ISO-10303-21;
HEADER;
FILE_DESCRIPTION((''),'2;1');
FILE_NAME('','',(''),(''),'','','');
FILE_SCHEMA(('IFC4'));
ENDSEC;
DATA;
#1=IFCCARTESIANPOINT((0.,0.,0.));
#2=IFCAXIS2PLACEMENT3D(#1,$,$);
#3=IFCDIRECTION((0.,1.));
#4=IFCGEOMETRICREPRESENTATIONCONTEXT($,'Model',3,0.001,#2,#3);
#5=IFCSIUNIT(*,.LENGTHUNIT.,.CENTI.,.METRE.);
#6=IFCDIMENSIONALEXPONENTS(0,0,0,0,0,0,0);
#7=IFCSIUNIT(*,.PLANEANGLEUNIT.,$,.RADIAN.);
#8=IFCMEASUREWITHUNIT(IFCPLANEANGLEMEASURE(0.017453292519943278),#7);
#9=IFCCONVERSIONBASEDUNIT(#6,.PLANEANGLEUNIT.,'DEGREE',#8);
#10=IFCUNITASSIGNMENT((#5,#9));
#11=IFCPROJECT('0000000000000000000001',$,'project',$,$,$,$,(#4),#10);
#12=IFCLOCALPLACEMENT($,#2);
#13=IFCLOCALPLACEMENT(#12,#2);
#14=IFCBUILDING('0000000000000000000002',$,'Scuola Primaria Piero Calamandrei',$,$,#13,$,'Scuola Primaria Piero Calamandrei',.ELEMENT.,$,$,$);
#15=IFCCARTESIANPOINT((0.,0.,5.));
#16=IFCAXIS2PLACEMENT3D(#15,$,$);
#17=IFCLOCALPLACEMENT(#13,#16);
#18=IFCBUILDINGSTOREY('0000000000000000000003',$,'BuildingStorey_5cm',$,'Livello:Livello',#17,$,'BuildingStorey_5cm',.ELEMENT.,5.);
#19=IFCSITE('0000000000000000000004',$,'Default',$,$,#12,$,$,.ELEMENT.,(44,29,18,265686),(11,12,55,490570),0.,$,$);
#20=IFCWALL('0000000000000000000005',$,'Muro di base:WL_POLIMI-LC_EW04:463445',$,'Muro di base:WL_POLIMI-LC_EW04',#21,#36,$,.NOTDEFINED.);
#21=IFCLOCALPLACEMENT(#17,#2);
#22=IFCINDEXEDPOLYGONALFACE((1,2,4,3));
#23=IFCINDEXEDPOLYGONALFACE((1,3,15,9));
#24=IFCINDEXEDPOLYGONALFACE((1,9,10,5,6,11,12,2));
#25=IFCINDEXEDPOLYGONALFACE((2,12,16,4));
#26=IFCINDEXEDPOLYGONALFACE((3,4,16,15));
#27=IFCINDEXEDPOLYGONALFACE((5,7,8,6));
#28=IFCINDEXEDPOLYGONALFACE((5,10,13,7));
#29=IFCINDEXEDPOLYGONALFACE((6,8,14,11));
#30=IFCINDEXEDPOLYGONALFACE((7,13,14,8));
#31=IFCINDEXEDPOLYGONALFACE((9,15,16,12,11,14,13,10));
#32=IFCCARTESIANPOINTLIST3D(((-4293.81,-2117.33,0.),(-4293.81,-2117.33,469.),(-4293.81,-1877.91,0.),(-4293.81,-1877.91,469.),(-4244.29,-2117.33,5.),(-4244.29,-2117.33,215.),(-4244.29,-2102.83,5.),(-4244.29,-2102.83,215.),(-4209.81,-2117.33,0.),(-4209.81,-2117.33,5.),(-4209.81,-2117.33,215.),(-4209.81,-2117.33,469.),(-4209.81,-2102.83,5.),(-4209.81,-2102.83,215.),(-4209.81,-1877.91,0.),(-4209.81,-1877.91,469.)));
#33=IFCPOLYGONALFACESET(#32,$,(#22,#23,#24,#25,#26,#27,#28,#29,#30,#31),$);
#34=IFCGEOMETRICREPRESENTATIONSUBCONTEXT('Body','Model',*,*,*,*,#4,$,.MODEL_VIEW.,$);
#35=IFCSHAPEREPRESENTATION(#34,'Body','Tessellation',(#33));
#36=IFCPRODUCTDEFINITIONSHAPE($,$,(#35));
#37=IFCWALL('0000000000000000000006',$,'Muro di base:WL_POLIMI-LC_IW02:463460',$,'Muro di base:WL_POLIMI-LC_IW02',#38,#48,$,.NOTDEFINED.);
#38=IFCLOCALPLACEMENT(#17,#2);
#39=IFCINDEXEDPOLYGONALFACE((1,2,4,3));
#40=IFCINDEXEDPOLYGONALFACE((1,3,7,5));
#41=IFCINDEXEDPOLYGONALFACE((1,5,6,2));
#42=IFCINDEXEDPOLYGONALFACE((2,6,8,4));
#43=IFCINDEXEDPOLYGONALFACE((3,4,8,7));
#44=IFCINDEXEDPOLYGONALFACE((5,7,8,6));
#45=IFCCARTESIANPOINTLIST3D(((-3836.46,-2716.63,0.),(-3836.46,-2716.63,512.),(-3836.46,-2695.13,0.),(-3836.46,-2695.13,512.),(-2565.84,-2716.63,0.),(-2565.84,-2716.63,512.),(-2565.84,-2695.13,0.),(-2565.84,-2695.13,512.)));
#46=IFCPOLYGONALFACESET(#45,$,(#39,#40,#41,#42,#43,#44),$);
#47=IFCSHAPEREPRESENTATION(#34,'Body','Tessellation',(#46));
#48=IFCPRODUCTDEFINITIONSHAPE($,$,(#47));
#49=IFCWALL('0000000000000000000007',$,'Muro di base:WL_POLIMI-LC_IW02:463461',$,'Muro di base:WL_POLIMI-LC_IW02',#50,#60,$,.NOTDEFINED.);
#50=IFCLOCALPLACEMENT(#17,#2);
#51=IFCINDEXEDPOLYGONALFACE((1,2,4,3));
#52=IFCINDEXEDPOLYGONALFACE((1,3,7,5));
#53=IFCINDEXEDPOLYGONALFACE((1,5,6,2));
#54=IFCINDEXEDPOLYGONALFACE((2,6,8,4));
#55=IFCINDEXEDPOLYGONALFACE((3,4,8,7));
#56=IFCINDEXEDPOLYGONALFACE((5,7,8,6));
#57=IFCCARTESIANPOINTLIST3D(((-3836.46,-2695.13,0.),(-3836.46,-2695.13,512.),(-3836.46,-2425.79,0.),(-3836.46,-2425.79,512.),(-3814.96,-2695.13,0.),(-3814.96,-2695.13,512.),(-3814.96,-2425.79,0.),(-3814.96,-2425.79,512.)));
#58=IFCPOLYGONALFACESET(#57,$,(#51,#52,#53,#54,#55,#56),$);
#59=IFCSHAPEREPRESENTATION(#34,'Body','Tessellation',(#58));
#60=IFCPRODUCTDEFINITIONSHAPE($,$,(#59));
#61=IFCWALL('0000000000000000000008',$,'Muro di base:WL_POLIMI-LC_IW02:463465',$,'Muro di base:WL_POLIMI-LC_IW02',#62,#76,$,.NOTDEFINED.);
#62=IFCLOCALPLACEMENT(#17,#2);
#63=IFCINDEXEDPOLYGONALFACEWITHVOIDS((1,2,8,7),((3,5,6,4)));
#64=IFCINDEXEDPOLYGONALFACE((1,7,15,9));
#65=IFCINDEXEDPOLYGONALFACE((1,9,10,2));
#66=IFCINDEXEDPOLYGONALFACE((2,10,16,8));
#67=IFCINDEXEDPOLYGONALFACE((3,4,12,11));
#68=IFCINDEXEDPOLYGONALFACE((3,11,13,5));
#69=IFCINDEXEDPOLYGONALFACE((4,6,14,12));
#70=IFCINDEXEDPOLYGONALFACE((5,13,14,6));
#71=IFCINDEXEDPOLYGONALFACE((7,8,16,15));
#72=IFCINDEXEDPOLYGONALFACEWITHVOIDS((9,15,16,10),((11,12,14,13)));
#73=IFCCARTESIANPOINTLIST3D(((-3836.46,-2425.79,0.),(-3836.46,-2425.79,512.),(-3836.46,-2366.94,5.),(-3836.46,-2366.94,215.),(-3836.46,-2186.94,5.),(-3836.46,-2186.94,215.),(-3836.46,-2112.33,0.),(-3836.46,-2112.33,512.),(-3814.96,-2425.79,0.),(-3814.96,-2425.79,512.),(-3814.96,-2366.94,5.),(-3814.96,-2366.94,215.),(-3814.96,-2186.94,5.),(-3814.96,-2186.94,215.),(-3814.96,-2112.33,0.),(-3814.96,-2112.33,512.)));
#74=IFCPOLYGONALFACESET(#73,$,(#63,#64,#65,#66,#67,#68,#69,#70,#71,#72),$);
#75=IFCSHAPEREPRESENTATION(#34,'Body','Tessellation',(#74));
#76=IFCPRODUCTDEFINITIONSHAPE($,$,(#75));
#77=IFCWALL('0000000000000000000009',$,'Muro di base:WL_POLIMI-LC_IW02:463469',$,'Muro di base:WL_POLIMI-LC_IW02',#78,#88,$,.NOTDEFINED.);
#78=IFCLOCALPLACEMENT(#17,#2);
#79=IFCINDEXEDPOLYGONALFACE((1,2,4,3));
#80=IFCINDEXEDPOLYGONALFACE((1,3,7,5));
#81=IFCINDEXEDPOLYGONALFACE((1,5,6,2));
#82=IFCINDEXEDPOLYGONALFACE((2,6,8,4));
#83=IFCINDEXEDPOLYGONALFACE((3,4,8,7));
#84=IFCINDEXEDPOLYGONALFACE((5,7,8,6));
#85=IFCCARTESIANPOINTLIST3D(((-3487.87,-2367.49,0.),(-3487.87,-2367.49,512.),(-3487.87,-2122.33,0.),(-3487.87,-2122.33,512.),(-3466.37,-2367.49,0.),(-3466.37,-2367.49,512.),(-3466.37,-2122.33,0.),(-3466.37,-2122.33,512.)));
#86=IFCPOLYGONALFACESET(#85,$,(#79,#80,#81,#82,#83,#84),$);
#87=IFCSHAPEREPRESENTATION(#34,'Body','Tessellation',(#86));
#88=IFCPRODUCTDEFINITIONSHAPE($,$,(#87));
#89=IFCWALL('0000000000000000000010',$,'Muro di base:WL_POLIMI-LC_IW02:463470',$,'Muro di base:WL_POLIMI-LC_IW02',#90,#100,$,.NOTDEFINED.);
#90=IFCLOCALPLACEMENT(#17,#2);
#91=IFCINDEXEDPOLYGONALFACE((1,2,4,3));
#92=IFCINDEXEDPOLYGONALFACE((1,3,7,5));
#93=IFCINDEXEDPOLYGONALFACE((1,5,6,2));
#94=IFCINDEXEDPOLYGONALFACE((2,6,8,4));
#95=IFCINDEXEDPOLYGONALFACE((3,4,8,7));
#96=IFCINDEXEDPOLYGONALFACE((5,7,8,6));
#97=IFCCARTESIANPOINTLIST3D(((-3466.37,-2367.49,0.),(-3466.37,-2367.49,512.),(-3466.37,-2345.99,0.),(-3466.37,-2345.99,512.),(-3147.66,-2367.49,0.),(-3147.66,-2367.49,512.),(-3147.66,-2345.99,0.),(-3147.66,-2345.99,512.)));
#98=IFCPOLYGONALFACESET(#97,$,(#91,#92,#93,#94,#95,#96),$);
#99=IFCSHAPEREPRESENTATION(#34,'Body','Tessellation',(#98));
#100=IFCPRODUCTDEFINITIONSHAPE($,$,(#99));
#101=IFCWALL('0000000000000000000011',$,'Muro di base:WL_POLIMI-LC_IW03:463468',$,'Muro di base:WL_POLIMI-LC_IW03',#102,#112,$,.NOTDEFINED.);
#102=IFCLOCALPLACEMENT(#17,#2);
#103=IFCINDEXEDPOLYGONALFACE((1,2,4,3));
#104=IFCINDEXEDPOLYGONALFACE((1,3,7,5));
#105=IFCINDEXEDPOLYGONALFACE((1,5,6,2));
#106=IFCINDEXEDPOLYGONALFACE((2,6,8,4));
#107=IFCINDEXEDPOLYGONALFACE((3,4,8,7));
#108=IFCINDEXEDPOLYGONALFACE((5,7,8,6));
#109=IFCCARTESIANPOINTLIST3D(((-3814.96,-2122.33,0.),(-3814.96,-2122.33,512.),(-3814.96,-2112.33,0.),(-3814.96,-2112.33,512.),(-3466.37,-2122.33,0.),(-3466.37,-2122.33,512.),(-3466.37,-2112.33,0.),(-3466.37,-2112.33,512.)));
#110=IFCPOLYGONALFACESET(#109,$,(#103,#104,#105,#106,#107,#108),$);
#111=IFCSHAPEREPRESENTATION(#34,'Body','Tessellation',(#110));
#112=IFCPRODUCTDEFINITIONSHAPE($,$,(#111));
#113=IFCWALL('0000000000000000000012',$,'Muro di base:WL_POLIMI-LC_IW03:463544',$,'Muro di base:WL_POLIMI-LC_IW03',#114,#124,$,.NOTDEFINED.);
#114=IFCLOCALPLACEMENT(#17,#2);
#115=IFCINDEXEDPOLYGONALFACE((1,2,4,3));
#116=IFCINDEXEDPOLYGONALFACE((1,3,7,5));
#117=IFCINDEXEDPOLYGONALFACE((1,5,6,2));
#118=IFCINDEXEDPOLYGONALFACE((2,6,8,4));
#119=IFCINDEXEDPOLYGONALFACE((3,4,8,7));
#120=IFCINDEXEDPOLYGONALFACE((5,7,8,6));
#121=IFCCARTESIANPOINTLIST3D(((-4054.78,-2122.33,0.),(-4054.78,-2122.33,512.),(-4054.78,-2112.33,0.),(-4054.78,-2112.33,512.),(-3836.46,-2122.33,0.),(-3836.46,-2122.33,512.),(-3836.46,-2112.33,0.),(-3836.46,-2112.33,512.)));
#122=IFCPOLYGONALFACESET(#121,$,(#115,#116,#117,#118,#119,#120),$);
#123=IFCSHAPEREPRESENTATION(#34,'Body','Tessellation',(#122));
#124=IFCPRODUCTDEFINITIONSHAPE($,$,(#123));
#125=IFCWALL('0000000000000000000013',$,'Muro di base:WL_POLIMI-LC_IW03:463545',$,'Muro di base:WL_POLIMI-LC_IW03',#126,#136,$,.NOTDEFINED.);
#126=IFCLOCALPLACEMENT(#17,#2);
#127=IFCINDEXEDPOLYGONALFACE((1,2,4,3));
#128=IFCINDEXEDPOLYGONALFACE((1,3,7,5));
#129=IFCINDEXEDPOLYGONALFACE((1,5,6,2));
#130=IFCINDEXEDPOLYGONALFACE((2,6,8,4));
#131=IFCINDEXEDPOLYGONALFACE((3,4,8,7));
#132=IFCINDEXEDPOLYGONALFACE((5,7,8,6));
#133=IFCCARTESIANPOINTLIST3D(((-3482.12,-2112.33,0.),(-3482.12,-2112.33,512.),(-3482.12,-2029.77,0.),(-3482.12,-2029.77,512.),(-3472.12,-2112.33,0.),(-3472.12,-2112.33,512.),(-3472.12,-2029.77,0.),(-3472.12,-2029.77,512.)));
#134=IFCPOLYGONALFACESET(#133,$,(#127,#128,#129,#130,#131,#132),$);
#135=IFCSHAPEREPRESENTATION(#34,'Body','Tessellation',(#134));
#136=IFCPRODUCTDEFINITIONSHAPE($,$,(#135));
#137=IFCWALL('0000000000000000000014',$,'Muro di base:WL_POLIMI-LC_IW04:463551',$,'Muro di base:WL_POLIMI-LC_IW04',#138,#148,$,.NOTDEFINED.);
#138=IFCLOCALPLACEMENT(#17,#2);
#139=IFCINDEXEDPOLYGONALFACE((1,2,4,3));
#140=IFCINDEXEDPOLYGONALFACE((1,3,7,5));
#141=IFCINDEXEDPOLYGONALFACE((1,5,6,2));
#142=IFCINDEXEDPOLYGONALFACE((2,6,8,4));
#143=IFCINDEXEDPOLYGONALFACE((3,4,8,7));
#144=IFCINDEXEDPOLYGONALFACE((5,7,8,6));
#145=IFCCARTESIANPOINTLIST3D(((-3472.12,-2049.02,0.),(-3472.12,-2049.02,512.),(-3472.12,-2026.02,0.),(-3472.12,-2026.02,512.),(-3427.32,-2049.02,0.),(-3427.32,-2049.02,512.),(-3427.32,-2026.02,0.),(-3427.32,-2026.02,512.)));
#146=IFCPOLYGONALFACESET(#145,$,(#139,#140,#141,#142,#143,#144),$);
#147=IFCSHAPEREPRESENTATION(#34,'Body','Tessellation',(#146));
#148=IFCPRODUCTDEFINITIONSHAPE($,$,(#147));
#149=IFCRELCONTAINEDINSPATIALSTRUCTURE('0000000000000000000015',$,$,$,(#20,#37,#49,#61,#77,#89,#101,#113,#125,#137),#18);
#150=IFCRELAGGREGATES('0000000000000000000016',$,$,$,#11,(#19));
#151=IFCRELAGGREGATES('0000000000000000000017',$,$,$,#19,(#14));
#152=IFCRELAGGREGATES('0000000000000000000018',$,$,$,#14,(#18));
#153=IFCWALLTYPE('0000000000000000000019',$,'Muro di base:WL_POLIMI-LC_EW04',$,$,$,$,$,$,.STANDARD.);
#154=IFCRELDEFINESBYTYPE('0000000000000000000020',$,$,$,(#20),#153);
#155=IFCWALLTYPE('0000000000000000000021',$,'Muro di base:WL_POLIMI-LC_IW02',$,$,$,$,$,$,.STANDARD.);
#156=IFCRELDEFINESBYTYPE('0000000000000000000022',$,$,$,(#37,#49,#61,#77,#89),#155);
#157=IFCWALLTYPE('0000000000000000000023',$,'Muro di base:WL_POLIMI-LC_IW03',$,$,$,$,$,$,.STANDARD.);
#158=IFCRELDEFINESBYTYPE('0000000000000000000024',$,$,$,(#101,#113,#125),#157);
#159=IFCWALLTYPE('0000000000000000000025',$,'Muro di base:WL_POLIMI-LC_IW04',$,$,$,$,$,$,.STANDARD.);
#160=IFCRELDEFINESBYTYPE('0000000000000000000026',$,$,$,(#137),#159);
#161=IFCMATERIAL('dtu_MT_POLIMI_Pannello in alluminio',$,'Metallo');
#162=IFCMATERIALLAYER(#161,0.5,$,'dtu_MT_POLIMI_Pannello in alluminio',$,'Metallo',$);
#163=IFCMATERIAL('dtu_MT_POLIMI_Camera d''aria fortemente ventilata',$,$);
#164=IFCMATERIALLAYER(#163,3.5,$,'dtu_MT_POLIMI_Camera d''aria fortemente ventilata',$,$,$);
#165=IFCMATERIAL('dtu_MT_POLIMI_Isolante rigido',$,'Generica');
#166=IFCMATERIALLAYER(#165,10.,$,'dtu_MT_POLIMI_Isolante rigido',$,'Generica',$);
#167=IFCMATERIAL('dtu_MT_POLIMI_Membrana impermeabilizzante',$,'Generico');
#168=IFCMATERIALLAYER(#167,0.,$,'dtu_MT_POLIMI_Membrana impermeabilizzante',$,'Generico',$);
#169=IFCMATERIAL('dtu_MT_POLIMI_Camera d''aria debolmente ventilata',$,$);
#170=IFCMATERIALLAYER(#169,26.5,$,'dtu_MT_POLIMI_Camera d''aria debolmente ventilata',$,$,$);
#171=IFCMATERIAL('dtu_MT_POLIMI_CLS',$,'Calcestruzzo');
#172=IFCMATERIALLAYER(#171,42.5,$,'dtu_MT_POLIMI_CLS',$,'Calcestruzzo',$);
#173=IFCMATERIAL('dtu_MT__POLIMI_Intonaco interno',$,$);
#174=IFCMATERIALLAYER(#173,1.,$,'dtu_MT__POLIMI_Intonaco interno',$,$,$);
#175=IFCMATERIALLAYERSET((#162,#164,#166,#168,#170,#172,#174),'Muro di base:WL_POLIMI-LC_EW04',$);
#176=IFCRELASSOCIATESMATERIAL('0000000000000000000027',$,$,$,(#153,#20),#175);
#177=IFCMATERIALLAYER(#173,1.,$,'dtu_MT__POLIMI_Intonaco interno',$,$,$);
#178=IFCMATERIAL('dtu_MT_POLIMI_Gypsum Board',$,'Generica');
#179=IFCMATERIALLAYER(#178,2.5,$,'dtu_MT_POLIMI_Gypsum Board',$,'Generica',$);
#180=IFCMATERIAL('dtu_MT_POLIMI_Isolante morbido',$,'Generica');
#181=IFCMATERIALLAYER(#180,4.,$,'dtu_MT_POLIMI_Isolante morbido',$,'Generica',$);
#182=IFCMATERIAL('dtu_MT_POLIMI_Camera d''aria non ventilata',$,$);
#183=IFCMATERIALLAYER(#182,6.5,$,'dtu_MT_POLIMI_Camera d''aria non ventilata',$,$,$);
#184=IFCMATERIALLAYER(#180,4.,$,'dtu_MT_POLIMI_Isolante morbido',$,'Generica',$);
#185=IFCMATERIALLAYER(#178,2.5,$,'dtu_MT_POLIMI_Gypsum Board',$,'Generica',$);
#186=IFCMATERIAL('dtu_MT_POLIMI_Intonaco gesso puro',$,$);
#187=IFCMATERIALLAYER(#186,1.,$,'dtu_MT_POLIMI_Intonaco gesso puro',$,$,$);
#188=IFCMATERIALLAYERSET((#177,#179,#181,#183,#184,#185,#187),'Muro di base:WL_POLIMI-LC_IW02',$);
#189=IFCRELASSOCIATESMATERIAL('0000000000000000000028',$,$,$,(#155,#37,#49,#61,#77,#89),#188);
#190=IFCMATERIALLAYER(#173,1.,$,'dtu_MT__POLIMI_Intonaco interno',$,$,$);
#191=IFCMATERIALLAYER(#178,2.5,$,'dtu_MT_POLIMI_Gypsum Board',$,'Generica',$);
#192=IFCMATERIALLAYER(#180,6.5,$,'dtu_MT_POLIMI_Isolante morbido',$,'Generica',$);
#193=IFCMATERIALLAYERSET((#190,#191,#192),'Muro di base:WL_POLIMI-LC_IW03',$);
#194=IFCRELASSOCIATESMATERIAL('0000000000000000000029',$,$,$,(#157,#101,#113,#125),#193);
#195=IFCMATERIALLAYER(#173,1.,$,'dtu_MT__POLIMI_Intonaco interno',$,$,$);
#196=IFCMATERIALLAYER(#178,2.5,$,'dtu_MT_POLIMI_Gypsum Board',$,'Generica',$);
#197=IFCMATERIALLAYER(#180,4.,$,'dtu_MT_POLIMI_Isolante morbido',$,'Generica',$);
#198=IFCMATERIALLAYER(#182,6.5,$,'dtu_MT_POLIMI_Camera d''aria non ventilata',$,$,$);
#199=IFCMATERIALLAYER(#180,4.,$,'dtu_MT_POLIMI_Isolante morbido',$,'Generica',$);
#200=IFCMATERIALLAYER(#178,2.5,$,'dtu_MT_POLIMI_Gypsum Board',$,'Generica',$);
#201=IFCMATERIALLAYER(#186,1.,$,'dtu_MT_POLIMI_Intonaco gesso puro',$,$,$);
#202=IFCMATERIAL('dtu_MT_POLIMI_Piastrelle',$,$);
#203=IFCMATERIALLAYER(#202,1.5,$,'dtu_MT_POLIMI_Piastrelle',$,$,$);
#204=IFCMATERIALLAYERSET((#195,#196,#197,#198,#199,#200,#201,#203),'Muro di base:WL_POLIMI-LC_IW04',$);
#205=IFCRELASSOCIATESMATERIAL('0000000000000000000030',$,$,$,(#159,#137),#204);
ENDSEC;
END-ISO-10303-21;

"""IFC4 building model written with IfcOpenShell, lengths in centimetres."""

from ifc_helpers import new_model, entity, si_unit, converted_unit, direction, frame, frame_2d, origin, place, context, subcontext, project, spatial, polyline, rectangle, extrude, clip, bounded_halfspace, material, layer, layer_set, layer_usage, type_object, element, save


model = new_model("IFC4")

# Units and contexts
model_context = context("Model", 3, precision=0.001, world=origin(), true_north=direction((0.0, 1.0)))
body_context = subcontext(model_context, "Body", "Model", "MODEL_VIEW")
ifc_project = project(units=[si_unit("LENGTHUNIT", "METRE", prefix="CENTI"), converted_unit("PLANEANGLEUNIT", "DEGREE", entity("IfcPlaneAngleMeasure", 0.017453292519943278), si_unit("PLANEANGLEUNIT", "RADIAN"), dimensions=[0, 0, 0, 0, 0, 0, 0])], contexts=[model_context])

# Site, building, storey
site_placement = place(None, origin())
site = spatial("IfcSite", under=ifc_project, at=site_placement, Name="Default", CompositionType="ELEMENT", RefLatitude=(44, 29, 18, 265686), RefLongitude=(11, 12, 55, 490570), RefElevation=0.0)
building_placement = place(site_placement, origin())
building = spatial("IfcBuilding", under=site, at=building_placement, Name="Scuola Primaria Piero Calamandrei", LongName="Scuola Primaria Piero Calamandrei", CompositionType="ELEMENT")
storey_placement = place(building_placement, frame((0.0, 0.0, 5.0)))
storey = spatial("IfcBuildingStorey", under=building, at=storey_placement, Name="BuildingStorey_5cm", ObjectType="Livello:Livello", LongName="BuildingStorey_5cm", CompositionType="ELEMENT", Elevation=5.0)

# Shared definitions
ifc_material_1 = material(Name="dtu_MT_POLIMI_Isolante rigido", Category="Generica")
ifc_material_2 = material(Name="dtu_MT_POLIMI_CLS", Category="Calcestruzzo")
ifc_material_3 = material(Name="dtu_MT_POLIMI_Intonaco gesso puro")

# Shared definitions
ifc_material_4 = material(Name="dtu_MT_POLIMI_Pannello in alluminio", Category="Metallo")
ifc_material_5 = material(Name="dtu_MT_POLIMI_Camera d'aria fortemente ventilata")
ifc_material_6 = material(Name="dtu_MT_POLIMI_Membrana impermeabilizzante", Category="Generico")
ifc_material_7 = material(Name="dtu_MT_POLIMI_Camera d'aria debolmente ventilata")
ifc_material_8 = material(Name="dtu_MT_POLIMI_Isolante morbido", Category="Generica")
ifc_material_9 = material(Name="dtu_MT_POLIMI_Gypsum Board", Category="Generica")
ifc_material_10 = material(Name="dtu_MT__POLIMI_Intonaco interno")

# Wall, opening
ifc_layer_1 = layer(ifc_material_4, 0.5, Name="dtu_MT_POLIMI_Pannello in alluminio", Category="Metallo")
ifc_layer_2 = layer(ifc_material_5, 3.5, Name="dtu_MT_POLIMI_Camera d'aria fortemente ventilata")
ifc_layer_3 = layer(ifc_material_1, 10.0, Name="dtu_MT_POLIMI_Isolante rigido", Category="Generica")
ifc_layer_4 = layer(ifc_material_6, 0.0, Name="dtu_MT_POLIMI_Membrana impermeabilizzante", Category="Generico")
ifc_layer_5 = layer(ifc_material_7, 26.5, Name="dtu_MT_POLIMI_Camera d'aria debolmente ventilata")
ifc_layer_6 = layer(ifc_material_2, 42.5, Name="dtu_MT_POLIMI_CLS", Category="Calcestruzzo")
ifc_layer_7 = layer(ifc_material_10, 1.0, Name="dtu_MT__POLIMI_Intonaco interno")
ifc_layer_set_1 = layer_set([ifc_layer_1, ifc_layer_2, ifc_layer_3, ifc_layer_4, ifc_layer_5, ifc_layer_6, ifc_layer_7], Name="Muro di base:WL_POLIMI-LC_EW04")
ifc_layer_usage_1 = layer_usage(ifc_layer_set_1, "AXIS2", "NEGATIVE", 42.0)
wall_type_1 = type_object("IfcWallType", Name="Muro di base:WL_POLIMI-LC_EW04", PredefinedType="STANDARD", material=ifc_layer_set_1)
wall_1_placement = place(storey_placement, frame((-4251.81, -2117.33, 0.0), z_axis=(0.0, 0.0, 1.0), x_axis=(0.0, 1.0, 0.0)))
wall_1 = element("IfcWall", 1, at=wall_1_placement, inside=storey, type_object=wall_type_1, material=ifc_layer_usage_1, Name="Muro di base:WL_POLIMI-LC_EW04:463445", ObjectType="Muro di base:WL_POLIMI-LC_EW04", PredefinedType="NOTDEFINED", context=body_context, shape_type="Clipping", body=[
    clip(extrude(rectangle(XDim=239.41, YDim=84.0, at=frame_2d((119.71, 0.0), x_axis=(-1.0, 0.0))), origin(), (0.0, 0.0, 1.0), 469.0), bounded_halfspace(frame((0.0, -42.0, 469.0), z_axis=(0.0, 0.0, -1.0), x_axis=(0.0, 1.0, 0.0)), True, frame((0.0, -42.0, 469.0)), polyline([(0.0, 0.0), (224.91, 0.0), (239.41, 0.0), (239.41, 84.0), (224.91, 84.0), (0.0, 84.0), (0.0, 44.0), (0.0, 0.0)]))),
])
opening_1_placement = place(wall_1_placement, frame((2117.33, -4251.81, 5.0)))
element("IfcOpeningElement", 2, at=opening_1_placement, cuts=wall_1, PredefinedType="OPENING", context=body_context, shape_type="SweptSolid", body=[
    extrude(rectangle(XDim=210.0, YDim=29.0, at=frame_2d((0.0, 0.0), x_axis=(0.0, 1.0))), frame((-2117.33, 4104.29, 105.0), z_axis=(0.0, 1.0, 0.0), x_axis=(1.0, 0.0, 0.0)), (0.0, 0.0, 1.0), 140.0),
])

# Walls
ifc_layer_8 = layer(ifc_material_10, 1.0, Name="dtu_MT__POLIMI_Intonaco interno")
ifc_layer_9 = layer(ifc_material_9, 2.5, Name="dtu_MT_POLIMI_Gypsum Board", Category="Generica")
ifc_layer_10 = layer(ifc_material_8, 4.0, Name="dtu_MT_POLIMI_Isolante morbido", Category="Generica")
ifc_material_11 = material(Name="dtu_MT_POLIMI_Camera d'aria non ventilata")
ifc_layer_11 = layer(ifc_material_11, 6.5, Name="dtu_MT_POLIMI_Camera d'aria non ventilata")
ifc_layer_12 = layer(ifc_material_8, 4.0, Name="dtu_MT_POLIMI_Isolante morbido", Category="Generica")
ifc_layer_13 = layer(ifc_material_9, 2.5, Name="dtu_MT_POLIMI_Gypsum Board", Category="Generica")
ifc_layer_14 = layer(ifc_material_3, 1.0, Name="dtu_MT_POLIMI_Intonaco gesso puro")
ifc_layer_set_2 = layer_set([ifc_layer_8, ifc_layer_9, ifc_layer_10, ifc_layer_11, ifc_layer_12, ifc_layer_13, ifc_layer_14], Name="Muro di base:WL_POLIMI-LC_IW02")
ifc_layer_usage_2 = layer_usage(ifc_layer_set_2, "AXIS2", "NEGATIVE", 10.75)
wall_type_2 = type_object("IfcWallType", Name="Muro di base:WL_POLIMI-LC_IW02", PredefinedType="STANDARD", material=ifc_layer_set_2)
wall_2_placement = place(storey_placement, frame((-3836.46, -2705.88, 0.0)))
element("IfcWall", 3, at=wall_2_placement, inside=storey, type_object=wall_type_2, material=ifc_layer_usage_2, Name="Muro di base:WL_POLIMI-LC_IW02:463460", ObjectType="Muro di base:WL_POLIMI-LC_IW02", PredefinedType="NOTDEFINED", context=body_context, shape_type="SweptSolid", body=[
    extrude(rectangle(XDim=1270.62, YDim=21.5, at=frame_2d((635.31, 0.0), x_axis=(-1.0, 0.0))), origin(), (0.0, 0.0, 1.0), 512.0),
])
ifc_layer_usage_3 = layer_usage(ifc_layer_set_2, "AXIS2", "NEGATIVE", 10.75)
wall_3_placement = place(storey_placement, frame((-3825.71, -2425.79, 0.0), z_axis=(0.0, 0.0, 1.0), x_axis=(0.0, -1.0, 0.0)))
element("IfcWall", 4, at=wall_3_placement, inside=storey, type_object=wall_type_2, material=ifc_layer_usage_3, Name="Muro di base:WL_POLIMI-LC_IW02:463461", ObjectType="Muro di base:WL_POLIMI-LC_IW02", PredefinedType="NOTDEFINED", context=body_context, shape_type="SweptSolid", body=[
    extrude(rectangle(XDim=269.34, YDim=21.5, at=frame_2d((134.67, 0.0), x_axis=(-1.0, 0.0))), origin(), (0.0, 0.0, 1.0), 512.0),
])

# Wall, opening
ifc_layer_usage_4 = layer_usage(ifc_layer_set_2, "AXIS2", "NEGATIVE", 10.75)
wall_4_placement = place(storey_placement, frame((-3825.71, -2425.79, 0.0), z_axis=(0.0, 0.0, 1.0), x_axis=(0.0, 1.0, 0.0)))
wall_4 = element("IfcWall", 5, at=wall_4_placement, inside=storey, type_object=wall_type_2, material=ifc_layer_usage_4, Name="Muro di base:WL_POLIMI-LC_IW02:463465", ObjectType="Muro di base:WL_POLIMI-LC_IW02", PredefinedType="NOTDEFINED", context=body_context, shape_type="SweptSolid", body=[
    extrude(rectangle(XDim=313.47, YDim=21.5, at=frame_2d((156.73, 0.0), x_axis=(-1.0, 0.0))), origin(), (0.0, 0.0, 1.0), 512.0),
])
opening_2_placement = place(wall_4_placement, frame((58.86, -10.75, 5.0)))
element("IfcOpeningElement", 6, at=opening_2_placement, cuts=wall_4, PredefinedType="OPENING", context=body_context, shape_type="SweptSolid", body=[
    extrude(rectangle(XDim=210.0, YDim=180.0, at=frame_2d((105.0, 90.0), x_axis=(-1.0, 0.0))), frame((0.0, 0.0, 0.0), z_axis=(0.0, 1.0, 0.0), x_axis=(0.0, 0.0, 1.0)), (0.0, 0.0, 1.0), 21.5),
])

# Walls
ifc_layer_usage_5 = layer_usage(ifc_layer_set_2, "AXIS2", "NEGATIVE", 10.75)
wall_5_placement = place(storey_placement, frame((-3477.12, -2122.33, 0.0), z_axis=(0.0, 0.0, 1.0), x_axis=(0.0, -1.0, 0.0)))
element("IfcWall", 7, at=wall_5_placement, inside=storey, type_object=wall_type_2, material=ifc_layer_usage_5, Name="Muro di base:WL_POLIMI-LC_IW02:463469", ObjectType="Muro di base:WL_POLIMI-LC_IW02", PredefinedType="NOTDEFINED", context=body_context, shape_type="SweptSolid", body=[
    extrude(rectangle(XDim=245.16, YDim=21.5, at=frame_2d((122.58, 0.0), x_axis=(-1.0, 0.0))), origin(), (0.0, 0.0, 1.0), 512.0),
])
ifc_layer_usage_6 = layer_usage(ifc_layer_set_2, "AXIS2", "NEGATIVE", 10.75)
wall_6_placement = place(storey_placement, frame((-3466.37, -2356.74, 0.0)))
element("IfcWall", 8, at=wall_6_placement, inside=storey, type_object=wall_type_2, material=ifc_layer_usage_6, Name="Muro di base:WL_POLIMI-LC_IW02:463470", ObjectType="Muro di base:WL_POLIMI-LC_IW02", PredefinedType="NOTDEFINED", context=body_context, shape_type="SweptSolid", body=[
    extrude(rectangle(XDim=318.71, YDim=21.5, at=frame_2d((159.35, 0.0), x_axis=(-1.0, 0.0))), origin(), (0.0, 0.0, 1.0), 512.0),
])
ifc_layer_15 = layer(ifc_material_10, 1.0, Name="dtu_MT__POLIMI_Intonaco interno")
ifc_layer_16 = layer(ifc_material_9, 2.5, Name="dtu_MT_POLIMI_Gypsum Board", Category="Generica")
ifc_layer_17 = layer(ifc_material_8, 6.5, Name="dtu_MT_POLIMI_Isolante morbido", Category="Generica")
ifc_layer_set_3 = layer_set([ifc_layer_15, ifc_layer_16, ifc_layer_17], Name="Muro di base:WL_POLIMI-LC_IW03")
ifc_layer_usage_7 = layer_usage(ifc_layer_set_3, "AXIS2", "NEGATIVE", 5.0)
wall_type_3 = type_object("IfcWallType", Name="Muro di base:WL_POLIMI-LC_IW03", PredefinedType="STANDARD", material=ifc_layer_set_3)
wall_7_placement = place(storey_placement, frame((-3814.96, -2117.33, 0.0)))
element("IfcWall", 9, at=wall_7_placement, inside=storey, type_object=wall_type_3, material=ifc_layer_usage_7, Name="Muro di base:WL_POLIMI-LC_IW03:463468", ObjectType="Muro di base:WL_POLIMI-LC_IW03", PredefinedType="NOTDEFINED", context=body_context, shape_type="SweptSolid", body=[
    extrude(rectangle(XDim=348.59, YDim=10.0, at=frame_2d((174.29, 0.0), x_axis=(-1.0, 0.0))), origin(), (0.0, 0.0, 1.0), 512.0),
])
ifc_layer_usage_8 = layer_usage(ifc_layer_set_3, "AXIS2", "NEGATIVE", 5.0)
wall_8_placement = place(storey_placement, frame((-4054.78, -2117.33, 0.0)))
element("IfcWall", 10, at=wall_8_placement, inside=storey, type_object=wall_type_3, material=ifc_layer_usage_8, Name="Muro di base:WL_POLIMI-LC_IW03:463544", ObjectType="Muro di base:WL_POLIMI-LC_IW03", PredefinedType="NOTDEFINED", context=body_context, shape_type="SweptSolid", body=[
    extrude(rectangle(XDim=218.32, YDim=10.0, at=frame_2d((109.16, 0.0), x_axis=(-1.0, 0.0))), origin(), (0.0, 0.0, 1.0), 512.0),
])
ifc_layer_usage_9 = layer_usage(ifc_layer_set_3, "AXIS2", "NEGATIVE", 5.0)
wall_9_placement = place(storey_placement, frame((-3477.12, -2029.77, 0.0), z_axis=(0.0, 0.0, 1.0), x_axis=(0.0, -1.0, 0.0)))
element("IfcWall", 11, at=wall_9_placement, inside=storey, type_object=wall_type_3, material=ifc_layer_usage_9, Name="Muro di base:WL_POLIMI-LC_IW03:463545", ObjectType="Muro di base:WL_POLIMI-LC_IW03", PredefinedType="NOTDEFINED", context=body_context, shape_type="SweptSolid", body=[
    extrude(rectangle(XDim=82.55, YDim=10.0, at=frame_2d((41.28, 0.0), x_axis=(-1.0, 0.0))), origin(), (0.0, 0.0, 1.0), 512.0),
])
ifc_layer_18 = layer(ifc_material_10, 1.0, Name="dtu_MT__POLIMI_Intonaco interno")
ifc_layer_19 = layer(ifc_material_9, 2.5, Name="dtu_MT_POLIMI_Gypsum Board", Category="Generica")
ifc_layer_20 = layer(ifc_material_8, 4.0, Name="dtu_MT_POLIMI_Isolante morbido", Category="Generica")
ifc_layer_21 = layer(ifc_material_11, 6.5, Name="dtu_MT_POLIMI_Camera d'aria non ventilata")
ifc_layer_22 = layer(ifc_material_8, 4.0, Name="dtu_MT_POLIMI_Isolante morbido", Category="Generica")
ifc_layer_23 = layer(ifc_material_9, 2.5, Name="dtu_MT_POLIMI_Gypsum Board", Category="Generica")
ifc_layer_24 = layer(ifc_material_3, 1.0, Name="dtu_MT_POLIMI_Intonaco gesso puro")
ifc_material_12 = material(Name="dtu_MT_POLIMI_Piastrelle")
ifc_layer_25 = layer(ifc_material_12, 1.5, Name="dtu_MT_POLIMI_Piastrelle")
ifc_layer_set_4 = layer_set([ifc_layer_18, ifc_layer_19, ifc_layer_20, ifc_layer_21, ifc_layer_22, ifc_layer_23, ifc_layer_24, ifc_layer_25], Name="Muro di base:WL_POLIMI-LC_IW04")
ifc_layer_usage_10 = layer_usage(ifc_layer_set_4, "AXIS2", "NEGATIVE", 11.5)
wall_type_4 = type_object("IfcWallType", Name="Muro di base:WL_POLIMI-LC_IW04", PredefinedType="STANDARD", material=ifc_layer_set_4)
wall_10_placement = place(storey_placement, frame((-3472.12, -2037.52, 0.0)))
element("IfcWall", 12, at=wall_10_placement, inside=storey, type_object=wall_type_4, material=ifc_layer_usage_10, Name="Muro di base:WL_POLIMI-LC_IW04:463551", ObjectType="Muro di base:WL_POLIMI-LC_IW04", PredefinedType="NOTDEFINED", context=body_context, shape_type="SweptSolid", body=[
    extrude(rectangle(XDim=44.8, YDim=23.0, at=frame_2d((22.4, 0.0), x_axis=(-1.0, 0.0))), origin(), (0.0, 0.0, 1.0), 512.0),
])

save(model, "model.ifc")
